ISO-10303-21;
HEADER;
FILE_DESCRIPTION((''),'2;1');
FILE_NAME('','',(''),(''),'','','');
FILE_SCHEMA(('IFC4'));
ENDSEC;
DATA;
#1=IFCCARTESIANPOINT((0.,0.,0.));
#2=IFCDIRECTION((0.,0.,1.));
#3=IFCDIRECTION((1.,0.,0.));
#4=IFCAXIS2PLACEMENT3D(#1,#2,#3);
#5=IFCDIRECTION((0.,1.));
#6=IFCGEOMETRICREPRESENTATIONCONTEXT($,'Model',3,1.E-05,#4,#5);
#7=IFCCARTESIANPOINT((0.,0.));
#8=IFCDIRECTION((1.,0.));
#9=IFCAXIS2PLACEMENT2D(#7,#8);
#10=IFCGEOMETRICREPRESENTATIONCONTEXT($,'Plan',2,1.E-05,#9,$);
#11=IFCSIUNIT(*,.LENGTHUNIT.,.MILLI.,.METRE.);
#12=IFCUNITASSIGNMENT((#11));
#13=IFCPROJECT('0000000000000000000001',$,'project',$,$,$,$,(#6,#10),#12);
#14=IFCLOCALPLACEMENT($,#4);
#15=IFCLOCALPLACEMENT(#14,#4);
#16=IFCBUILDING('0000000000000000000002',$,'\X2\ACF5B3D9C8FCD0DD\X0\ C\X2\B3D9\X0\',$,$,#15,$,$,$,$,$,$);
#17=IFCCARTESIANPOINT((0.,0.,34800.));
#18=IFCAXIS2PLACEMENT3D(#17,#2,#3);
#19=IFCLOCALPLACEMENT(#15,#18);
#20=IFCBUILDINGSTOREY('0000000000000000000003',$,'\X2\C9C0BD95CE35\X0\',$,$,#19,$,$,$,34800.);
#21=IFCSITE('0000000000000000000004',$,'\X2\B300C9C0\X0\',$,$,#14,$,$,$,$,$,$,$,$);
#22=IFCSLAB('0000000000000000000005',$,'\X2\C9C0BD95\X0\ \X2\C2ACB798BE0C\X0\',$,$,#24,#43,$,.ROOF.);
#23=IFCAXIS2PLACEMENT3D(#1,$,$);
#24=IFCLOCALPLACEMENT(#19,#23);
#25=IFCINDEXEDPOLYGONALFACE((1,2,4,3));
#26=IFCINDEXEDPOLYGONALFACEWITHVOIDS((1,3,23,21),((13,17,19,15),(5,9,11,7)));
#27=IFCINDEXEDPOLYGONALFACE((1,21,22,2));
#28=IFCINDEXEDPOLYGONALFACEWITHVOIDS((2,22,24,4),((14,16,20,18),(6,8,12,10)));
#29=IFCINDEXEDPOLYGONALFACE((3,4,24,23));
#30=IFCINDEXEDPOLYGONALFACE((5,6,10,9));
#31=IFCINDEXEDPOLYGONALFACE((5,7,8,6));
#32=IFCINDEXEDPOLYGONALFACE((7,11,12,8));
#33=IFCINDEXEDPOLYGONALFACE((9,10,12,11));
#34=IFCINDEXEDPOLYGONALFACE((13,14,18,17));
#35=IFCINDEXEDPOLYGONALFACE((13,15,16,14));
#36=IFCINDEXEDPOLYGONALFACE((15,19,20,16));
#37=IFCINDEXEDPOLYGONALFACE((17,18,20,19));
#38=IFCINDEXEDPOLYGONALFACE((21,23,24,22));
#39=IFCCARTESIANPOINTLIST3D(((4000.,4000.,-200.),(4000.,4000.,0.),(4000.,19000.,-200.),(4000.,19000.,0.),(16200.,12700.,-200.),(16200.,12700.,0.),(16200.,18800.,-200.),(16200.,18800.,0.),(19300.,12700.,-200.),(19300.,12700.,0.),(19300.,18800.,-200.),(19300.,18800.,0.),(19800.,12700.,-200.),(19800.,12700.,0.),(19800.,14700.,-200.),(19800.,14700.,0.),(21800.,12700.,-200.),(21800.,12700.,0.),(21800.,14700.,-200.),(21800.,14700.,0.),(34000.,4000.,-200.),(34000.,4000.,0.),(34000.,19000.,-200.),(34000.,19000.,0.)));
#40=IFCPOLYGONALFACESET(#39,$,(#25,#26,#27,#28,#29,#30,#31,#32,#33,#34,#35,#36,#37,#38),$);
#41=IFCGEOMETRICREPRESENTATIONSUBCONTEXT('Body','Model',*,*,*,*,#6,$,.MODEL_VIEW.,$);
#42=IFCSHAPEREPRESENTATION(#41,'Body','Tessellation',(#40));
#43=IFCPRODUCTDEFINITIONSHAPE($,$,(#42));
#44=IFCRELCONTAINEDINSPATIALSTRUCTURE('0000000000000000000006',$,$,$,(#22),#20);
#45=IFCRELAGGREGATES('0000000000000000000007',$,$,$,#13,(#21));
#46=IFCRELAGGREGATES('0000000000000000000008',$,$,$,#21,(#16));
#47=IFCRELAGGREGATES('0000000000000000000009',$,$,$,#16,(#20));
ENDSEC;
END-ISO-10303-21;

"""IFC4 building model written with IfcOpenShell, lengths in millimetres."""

from ifc_helpers import new_model, si_unit, direction, frame, origin_with_axes, origin_2d_with_axis, place, context, subcontext, project, spatial, polyline, outline, extrude, element, save


model = new_model("IFC4")

# Units and contexts
model_context = context("Model", 3, precision=1e-05, world=origin_with_axes(), true_north=direction((0.0, 1.0)))
plan_context = context("Plan", 2, precision=1e-05, world=origin_2d_with_axis())
body_context = subcontext(model_context, "Body", "Model", "MODEL_VIEW")
ifc_project = project(units=[si_unit("LENGTHUNIT", "METRE", prefix="MILLI")], contexts=[model_context, plan_context])

# Site, building, storey
site_placement = place(None, origin_with_axes())
site = spatial("IfcSite", under=ifc_project, at=site_placement, Name="대지")
building_placement = place(site_placement, origin_with_axes())
building = spatial("IfcBuilding", under=site, at=building_placement, Name="공동주택 C동")
storey_placement = place(building_placement, frame((0.0, 0.0, 34800.0), z_axis=(0.0, 0.0, 1.0), x_axis=(1.0, 0.0, 0.0)))
storey = spatial("IfcBuildingStorey", under=building, at=storey_placement, Name="지붕층", Elevation=34800.0)

# Slab
slab_placement = place(storey_placement, origin_with_axes())
element("IfcSlab", 1, at=slab_placement, inside=storey, Name="지붕 슬래브", PredefinedType="ROOF", context=body_context, shape_type="SweptSolid", body=[
    extrude(outline(polyline([(4000.0, 4000.0), (34000.0, 4000.0), (34000.0, 19000.0), (4000.0, 19000.0), (4000.0, 4000.0)]), holes=[polyline([(16200.0, 12700.0), (19300.0, 12700.0), (19300.0, 18800.0), (16200.0, 18800.0), (16200.0, 12700.0)]), polyline([(19800.0, 12700.0), (21800.0, 12700.0), (21800.0, 14700.0), (19800.0, 14700.0), (19800.0, 12700.0)])]), frame((0.0, 0.0, -200.0), z_axis=(0.0, 0.0, 1.0), x_axis=(1.0, 0.0, 0.0)), (0.0, 0.0, 1.0), 200.0),
])

save(model, "model.ifc")
